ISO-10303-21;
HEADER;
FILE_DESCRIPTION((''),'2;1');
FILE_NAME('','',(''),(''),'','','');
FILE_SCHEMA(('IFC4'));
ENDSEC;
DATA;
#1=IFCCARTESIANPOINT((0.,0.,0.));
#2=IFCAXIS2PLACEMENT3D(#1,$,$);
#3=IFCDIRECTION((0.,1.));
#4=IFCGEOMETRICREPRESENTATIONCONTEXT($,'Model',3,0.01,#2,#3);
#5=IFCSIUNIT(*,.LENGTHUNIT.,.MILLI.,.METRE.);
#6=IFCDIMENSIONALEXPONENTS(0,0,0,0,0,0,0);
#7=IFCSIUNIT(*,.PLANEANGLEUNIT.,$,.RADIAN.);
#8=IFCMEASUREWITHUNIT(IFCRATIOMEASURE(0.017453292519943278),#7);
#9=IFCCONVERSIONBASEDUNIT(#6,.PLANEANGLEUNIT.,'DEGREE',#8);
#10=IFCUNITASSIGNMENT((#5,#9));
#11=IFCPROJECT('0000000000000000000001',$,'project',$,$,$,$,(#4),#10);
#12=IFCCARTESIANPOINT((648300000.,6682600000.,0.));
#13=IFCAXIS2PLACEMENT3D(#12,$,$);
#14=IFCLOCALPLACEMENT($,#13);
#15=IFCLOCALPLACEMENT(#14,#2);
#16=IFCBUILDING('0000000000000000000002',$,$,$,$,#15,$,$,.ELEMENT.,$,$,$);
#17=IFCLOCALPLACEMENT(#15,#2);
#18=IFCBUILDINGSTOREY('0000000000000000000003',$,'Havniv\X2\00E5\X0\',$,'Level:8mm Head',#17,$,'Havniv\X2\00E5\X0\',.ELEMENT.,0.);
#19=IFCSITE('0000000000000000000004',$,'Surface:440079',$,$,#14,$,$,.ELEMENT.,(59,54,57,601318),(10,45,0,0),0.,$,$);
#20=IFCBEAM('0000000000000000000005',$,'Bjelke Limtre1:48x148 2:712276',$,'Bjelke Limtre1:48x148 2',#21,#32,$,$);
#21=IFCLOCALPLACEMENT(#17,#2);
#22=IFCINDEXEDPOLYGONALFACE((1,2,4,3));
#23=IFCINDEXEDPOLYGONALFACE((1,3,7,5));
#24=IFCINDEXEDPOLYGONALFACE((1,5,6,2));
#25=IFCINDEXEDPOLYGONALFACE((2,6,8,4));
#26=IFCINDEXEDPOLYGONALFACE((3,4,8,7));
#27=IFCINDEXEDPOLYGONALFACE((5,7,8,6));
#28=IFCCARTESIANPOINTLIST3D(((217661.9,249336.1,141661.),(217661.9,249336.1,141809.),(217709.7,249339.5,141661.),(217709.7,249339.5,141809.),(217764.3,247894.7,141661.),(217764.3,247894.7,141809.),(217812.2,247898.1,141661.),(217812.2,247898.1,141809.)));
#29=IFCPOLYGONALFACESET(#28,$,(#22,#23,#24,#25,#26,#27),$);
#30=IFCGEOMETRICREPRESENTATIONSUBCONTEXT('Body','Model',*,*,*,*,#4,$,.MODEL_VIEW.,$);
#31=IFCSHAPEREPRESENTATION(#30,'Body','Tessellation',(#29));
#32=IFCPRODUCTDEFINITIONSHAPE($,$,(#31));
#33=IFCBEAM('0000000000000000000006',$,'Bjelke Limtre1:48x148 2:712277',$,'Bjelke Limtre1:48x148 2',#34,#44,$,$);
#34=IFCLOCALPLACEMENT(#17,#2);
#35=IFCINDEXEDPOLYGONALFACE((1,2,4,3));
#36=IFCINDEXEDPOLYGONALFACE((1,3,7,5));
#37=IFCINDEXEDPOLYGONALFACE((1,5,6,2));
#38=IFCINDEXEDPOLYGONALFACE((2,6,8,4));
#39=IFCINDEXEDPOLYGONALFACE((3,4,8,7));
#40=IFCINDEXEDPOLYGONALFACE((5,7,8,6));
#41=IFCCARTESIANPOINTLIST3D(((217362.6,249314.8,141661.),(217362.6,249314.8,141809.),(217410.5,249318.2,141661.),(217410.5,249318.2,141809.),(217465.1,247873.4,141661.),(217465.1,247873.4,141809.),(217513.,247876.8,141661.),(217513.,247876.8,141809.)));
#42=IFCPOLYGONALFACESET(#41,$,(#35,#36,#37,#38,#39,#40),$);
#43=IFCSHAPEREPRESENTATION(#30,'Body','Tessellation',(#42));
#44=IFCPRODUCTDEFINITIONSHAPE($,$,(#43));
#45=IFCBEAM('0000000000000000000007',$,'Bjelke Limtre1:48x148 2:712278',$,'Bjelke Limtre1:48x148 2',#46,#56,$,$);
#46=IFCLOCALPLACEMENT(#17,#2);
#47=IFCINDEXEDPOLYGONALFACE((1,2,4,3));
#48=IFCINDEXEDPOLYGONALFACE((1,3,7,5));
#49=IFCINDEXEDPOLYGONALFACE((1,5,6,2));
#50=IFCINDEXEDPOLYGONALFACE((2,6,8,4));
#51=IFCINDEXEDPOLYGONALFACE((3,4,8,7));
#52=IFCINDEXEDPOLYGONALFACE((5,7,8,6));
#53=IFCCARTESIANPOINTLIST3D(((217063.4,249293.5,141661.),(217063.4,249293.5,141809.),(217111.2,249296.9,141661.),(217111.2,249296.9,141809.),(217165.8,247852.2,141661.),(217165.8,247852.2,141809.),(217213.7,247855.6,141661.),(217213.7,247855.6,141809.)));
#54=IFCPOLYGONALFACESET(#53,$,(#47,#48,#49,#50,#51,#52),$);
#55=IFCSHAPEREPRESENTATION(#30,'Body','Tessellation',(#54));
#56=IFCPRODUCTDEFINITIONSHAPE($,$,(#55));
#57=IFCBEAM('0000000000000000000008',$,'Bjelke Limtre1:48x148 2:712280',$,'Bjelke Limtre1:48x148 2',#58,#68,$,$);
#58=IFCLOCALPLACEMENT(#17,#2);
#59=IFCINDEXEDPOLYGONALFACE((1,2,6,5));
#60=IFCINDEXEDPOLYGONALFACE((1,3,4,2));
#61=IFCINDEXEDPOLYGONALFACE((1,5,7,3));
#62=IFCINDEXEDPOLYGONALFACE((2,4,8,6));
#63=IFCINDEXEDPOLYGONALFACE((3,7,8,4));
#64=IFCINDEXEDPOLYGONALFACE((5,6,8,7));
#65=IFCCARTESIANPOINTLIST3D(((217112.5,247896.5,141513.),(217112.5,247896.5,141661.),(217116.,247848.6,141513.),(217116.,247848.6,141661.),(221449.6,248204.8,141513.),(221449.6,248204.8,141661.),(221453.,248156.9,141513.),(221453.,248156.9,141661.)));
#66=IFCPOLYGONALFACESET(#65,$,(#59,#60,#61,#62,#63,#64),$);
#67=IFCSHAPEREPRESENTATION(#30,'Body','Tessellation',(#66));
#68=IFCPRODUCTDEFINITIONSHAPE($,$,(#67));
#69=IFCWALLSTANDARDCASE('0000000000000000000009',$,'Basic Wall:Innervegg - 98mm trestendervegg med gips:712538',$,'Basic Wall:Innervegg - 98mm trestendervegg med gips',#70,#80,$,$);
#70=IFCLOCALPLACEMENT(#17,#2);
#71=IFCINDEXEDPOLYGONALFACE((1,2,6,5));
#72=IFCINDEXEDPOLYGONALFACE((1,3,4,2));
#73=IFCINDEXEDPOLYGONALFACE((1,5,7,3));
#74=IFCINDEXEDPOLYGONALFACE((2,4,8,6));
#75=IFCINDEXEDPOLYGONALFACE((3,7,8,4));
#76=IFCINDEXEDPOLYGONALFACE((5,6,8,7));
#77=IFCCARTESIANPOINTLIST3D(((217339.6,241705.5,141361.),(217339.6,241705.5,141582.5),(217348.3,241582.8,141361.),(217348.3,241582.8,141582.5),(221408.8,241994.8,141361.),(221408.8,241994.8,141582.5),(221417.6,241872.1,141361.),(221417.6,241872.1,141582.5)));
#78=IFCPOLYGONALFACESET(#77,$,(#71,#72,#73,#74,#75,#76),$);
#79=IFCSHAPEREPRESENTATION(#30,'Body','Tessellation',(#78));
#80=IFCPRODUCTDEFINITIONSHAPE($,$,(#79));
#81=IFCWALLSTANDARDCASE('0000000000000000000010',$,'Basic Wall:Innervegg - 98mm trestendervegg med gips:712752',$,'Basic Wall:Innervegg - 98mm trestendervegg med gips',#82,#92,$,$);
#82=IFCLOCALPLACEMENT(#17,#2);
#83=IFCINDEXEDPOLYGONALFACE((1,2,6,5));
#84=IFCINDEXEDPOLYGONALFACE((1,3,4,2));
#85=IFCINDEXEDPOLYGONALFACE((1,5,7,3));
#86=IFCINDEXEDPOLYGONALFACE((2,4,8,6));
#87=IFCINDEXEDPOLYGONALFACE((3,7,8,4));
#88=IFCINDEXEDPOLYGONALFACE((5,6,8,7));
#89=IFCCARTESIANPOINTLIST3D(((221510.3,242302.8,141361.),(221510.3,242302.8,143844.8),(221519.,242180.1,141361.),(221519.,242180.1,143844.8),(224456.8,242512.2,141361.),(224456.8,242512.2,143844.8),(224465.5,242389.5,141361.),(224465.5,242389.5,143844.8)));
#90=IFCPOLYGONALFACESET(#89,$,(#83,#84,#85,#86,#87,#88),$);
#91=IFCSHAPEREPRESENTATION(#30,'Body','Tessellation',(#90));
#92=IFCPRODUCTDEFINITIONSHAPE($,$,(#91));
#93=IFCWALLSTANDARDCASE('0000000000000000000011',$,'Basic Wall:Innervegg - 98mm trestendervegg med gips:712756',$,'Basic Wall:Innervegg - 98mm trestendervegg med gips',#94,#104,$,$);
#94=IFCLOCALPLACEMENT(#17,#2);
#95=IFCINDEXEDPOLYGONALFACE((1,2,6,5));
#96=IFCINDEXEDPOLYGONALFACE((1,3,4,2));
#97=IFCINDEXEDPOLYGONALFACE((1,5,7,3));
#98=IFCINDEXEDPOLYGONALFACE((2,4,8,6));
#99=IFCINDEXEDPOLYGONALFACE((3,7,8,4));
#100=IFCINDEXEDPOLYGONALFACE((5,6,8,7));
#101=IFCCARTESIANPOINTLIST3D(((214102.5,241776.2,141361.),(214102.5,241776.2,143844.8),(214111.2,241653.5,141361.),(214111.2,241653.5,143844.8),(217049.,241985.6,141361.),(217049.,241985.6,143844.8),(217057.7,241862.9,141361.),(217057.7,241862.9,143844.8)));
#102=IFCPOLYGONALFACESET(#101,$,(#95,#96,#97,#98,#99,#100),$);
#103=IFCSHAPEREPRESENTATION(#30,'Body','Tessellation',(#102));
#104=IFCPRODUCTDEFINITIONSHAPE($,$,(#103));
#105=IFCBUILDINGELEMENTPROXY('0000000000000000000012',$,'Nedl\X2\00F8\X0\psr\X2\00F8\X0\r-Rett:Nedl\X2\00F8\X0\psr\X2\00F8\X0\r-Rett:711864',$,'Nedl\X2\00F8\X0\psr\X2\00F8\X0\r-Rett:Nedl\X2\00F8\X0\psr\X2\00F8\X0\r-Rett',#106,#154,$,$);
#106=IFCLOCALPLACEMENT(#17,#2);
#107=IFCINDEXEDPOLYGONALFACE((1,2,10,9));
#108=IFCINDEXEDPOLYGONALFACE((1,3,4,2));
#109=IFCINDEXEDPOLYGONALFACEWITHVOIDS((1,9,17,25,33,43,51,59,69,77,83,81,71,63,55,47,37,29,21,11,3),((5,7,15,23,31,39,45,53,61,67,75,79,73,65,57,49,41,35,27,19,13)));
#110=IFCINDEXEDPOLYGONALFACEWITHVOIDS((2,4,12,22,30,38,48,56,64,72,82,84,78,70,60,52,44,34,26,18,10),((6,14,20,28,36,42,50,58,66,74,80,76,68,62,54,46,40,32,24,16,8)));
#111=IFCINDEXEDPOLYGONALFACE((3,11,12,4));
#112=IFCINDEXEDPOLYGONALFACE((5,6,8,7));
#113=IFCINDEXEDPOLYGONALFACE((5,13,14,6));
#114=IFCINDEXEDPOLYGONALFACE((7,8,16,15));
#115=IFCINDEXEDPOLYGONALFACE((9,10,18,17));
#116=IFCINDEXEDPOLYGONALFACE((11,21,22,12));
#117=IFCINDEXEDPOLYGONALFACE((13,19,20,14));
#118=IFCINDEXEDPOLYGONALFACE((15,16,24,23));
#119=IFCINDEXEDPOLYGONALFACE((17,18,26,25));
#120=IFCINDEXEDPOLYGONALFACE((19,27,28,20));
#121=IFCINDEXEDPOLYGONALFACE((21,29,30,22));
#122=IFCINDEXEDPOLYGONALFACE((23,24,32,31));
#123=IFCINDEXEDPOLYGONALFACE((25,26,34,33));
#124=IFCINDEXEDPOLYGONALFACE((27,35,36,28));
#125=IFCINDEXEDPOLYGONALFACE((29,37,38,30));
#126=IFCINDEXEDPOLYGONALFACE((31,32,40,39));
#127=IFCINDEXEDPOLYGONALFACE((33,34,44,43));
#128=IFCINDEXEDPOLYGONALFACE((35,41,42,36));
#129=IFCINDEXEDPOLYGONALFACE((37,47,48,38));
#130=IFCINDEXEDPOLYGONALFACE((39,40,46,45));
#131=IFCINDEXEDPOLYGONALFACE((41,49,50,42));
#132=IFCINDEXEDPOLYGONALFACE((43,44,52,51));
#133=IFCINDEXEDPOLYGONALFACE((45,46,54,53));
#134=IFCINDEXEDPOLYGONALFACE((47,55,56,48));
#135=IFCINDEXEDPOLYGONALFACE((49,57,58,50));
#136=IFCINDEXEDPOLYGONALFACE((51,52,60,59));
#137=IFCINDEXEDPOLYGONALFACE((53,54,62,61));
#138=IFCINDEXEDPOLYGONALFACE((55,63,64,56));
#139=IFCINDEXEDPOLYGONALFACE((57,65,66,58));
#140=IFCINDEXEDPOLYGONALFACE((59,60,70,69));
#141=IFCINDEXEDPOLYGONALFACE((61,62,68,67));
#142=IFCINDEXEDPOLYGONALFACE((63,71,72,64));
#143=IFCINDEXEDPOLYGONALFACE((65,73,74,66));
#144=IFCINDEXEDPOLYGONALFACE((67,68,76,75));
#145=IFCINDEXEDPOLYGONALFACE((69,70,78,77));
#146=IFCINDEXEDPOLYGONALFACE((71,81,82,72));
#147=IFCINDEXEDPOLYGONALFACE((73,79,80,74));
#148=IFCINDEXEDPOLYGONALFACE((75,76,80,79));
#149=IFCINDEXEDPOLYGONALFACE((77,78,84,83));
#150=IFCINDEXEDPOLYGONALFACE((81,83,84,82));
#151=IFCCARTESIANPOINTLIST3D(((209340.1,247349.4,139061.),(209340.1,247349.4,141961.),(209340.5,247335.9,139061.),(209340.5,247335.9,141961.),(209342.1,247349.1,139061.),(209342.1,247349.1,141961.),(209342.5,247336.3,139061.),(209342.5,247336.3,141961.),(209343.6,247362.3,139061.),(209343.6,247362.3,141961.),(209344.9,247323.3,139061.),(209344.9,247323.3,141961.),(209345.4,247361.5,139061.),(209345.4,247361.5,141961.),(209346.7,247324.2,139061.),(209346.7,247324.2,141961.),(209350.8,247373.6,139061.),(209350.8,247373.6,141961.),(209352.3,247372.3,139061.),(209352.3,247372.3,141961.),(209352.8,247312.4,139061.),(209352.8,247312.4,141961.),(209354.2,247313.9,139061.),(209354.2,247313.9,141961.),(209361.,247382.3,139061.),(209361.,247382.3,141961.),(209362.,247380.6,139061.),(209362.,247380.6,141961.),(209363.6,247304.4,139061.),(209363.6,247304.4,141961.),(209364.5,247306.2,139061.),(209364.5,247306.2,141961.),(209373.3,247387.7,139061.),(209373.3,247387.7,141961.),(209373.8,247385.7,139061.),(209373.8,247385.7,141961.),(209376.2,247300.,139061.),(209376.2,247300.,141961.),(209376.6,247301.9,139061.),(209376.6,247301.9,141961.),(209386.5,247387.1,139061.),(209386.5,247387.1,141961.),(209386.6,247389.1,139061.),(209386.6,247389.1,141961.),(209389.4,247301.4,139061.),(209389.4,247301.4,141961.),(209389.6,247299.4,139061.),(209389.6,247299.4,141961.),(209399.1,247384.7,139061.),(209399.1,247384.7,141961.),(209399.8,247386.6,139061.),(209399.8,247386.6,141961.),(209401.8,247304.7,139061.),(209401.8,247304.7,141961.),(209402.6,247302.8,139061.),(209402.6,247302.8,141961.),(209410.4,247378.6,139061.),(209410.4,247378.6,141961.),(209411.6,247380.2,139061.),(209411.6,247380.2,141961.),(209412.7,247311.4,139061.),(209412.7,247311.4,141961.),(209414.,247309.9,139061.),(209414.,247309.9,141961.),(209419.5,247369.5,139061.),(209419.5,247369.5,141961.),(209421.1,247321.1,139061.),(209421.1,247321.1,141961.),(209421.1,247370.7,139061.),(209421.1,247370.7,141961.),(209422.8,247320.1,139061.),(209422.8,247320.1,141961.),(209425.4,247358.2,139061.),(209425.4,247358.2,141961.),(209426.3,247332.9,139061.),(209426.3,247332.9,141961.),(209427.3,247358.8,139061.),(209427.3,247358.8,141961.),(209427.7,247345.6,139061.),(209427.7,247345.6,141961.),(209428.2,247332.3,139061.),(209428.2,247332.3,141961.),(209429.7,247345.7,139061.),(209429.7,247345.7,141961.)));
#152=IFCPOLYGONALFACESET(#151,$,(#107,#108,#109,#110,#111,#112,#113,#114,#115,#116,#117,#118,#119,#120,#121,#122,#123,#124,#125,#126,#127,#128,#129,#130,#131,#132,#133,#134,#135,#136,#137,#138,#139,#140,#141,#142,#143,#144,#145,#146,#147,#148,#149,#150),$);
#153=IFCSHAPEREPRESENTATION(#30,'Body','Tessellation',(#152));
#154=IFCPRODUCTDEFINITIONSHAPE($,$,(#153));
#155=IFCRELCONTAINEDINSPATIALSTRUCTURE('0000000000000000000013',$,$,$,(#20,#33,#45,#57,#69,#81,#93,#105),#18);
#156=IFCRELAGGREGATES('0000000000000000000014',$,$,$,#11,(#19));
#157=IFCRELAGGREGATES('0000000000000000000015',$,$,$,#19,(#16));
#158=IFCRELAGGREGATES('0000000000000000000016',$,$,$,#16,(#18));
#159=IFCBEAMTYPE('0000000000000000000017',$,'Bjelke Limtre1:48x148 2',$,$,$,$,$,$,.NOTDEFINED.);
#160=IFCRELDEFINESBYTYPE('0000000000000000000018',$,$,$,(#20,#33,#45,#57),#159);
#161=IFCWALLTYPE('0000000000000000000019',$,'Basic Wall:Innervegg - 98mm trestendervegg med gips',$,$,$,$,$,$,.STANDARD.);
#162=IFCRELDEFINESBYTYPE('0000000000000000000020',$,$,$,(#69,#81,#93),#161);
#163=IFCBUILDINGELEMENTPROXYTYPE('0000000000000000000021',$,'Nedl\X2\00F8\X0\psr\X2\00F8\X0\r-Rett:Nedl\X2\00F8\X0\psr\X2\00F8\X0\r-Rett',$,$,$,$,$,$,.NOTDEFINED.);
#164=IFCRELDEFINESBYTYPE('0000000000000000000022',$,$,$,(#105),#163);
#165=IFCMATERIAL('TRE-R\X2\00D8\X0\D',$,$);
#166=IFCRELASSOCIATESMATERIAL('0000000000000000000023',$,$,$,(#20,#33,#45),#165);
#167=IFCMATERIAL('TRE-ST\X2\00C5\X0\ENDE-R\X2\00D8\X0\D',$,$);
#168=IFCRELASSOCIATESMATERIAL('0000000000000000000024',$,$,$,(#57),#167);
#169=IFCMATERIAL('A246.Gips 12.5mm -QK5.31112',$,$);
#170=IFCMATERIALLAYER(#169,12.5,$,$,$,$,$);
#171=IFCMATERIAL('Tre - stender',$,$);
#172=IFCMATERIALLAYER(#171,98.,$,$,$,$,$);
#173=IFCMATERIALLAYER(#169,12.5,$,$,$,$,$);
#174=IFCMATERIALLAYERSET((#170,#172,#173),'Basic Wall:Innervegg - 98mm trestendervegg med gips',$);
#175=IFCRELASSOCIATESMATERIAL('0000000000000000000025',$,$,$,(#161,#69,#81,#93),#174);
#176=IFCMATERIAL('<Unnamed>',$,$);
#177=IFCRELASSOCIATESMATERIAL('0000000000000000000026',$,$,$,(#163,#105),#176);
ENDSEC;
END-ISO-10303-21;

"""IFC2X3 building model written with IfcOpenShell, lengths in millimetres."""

from ifc_helpers import new_model, entity, si_unit, converted_unit, direction, frame, frame_2d, origin, origin_2d_with_axis, place, context, subcontext, project, spatial, rectangle, hollow_circle, extrude, source, transform, mapped, material, layer, layer_set, layer_usage, type_object, type_shapes, element, save


model = new_model("IFC2X3")

# Units and contexts
model_context = context("Model", 3, precision=0.01, world=origin(), true_north=direction((0.0, 1.0)))
body_context = subcontext(model_context, "Body", "Model", "MODEL_VIEW")
ifc_project = project(units=[si_unit("LENGTHUNIT", "METRE", prefix="MILLI"), converted_unit("PLANEANGLEUNIT", "DEGREE", entity("IfcRatioMeasure", 0.017453292519943278), si_unit("PLANEANGLEUNIT", "RADIAN"), dimensions=[0, 0, 0, 0, 0, 0, 0])], contexts=[model_context])

# Site, building, storey
site_placement = place(None, frame((648300000.0, 6682600000.0, 0.0)))
site = spatial("IfcSite", under=ifc_project, at=site_placement, Name="Surface:440079", CompositionType="ELEMENT", RefLatitude=(59, 54, 57, 601318), RefLongitude=(10, 45, 0, 0), RefElevation=0.0)
building_placement = place(site_placement, origin())
building = spatial("IfcBuilding", under=site, at=building_placement, CompositionType="ELEMENT")
storey_placement = place(building_placement, origin())
storey = spatial("IfcBuildingStorey", under=building, at=storey_placement, Name="Havnivå", ObjectType="Level:8mm Head", LongName="Havnivå", CompositionType="ELEMENT", Elevation=0.0)

# Beams
ifc_material_1 = material(Name="TRE-RØD")
beam_type = type_object("IfcBeamType", Name="Bjelke Limtre1:48x148 2", PredefinedType="NOTDEFINED")
ifc_material_2 = material(Name="TRE-STÅENDE-RØD")
for number, where, z_axis, x_axis, name in (
    (1, (217685.8, 249337.8, 141809.0), (0.0, 0.0, 1.0), (0.070908, -0.997483, 0.0), "Bjelke Limtre1:48x148 2:712276"),
    (2, (217386.5, 249316.5, 141809.0), (0.0, 0.0, 1.0), (0.070908, -0.997483, 0.0), "Bjelke Limtre1:48x148 2:712277"),
    (3, (217087.3, 249295.2, 141809.0), (0.0, 0.0, 1.0), (0.070908, -0.997483, 0.0), "Bjelke Limtre1:48x148 2:712278"),
):
    element("IfcBeam", number, at=place(storey_placement, frame(where, z_axis=z_axis, x_axis=x_axis)), inside=storey, type_object=beam_type, material=ifc_material_1, Name=name, ObjectType="Bjelke Limtre1:48x148 2", context=body_context, shape_type="SweptSolid", body=[
        extrude(rectangle(XDim=148.0, YDim=48.0, at=origin_2d_with_axis()), frame((0.0, 0.0, -74.0), z_axis=(1.0, 0.0, 0.0), x_axis=(0.0, 0.0, -1.0)), (0.0, 0.0, 1.0), 1445.0),
    ])
beam_1_placement = place(storey_placement, frame((217114.3, 247872.6, 141661.0), z_axis=(0.0, 0.0, 1.0), x_axis=(0.997483, 0.070908, 0.0)))
element("IfcBeam", 4, at=beam_1_placement, inside=storey, type_object=beam_type, material=ifc_material_2, Name="Bjelke Limtre1:48x148 2:712280", ObjectType="Bjelke Limtre1:48x148 2", context=body_context, shape_type="SweptSolid", body=[
    extrude(rectangle(XDim=148.0, YDim=48.0, at=frame_2d((0.0, 0.0), x_axis=(1.0, 0.0))), frame((0.0, 0.0, -74.0), z_axis=(1.0, 0.0, 0.0), x_axis=(0.0, 0.0, -1.0)), (0.0, 0.0, 1.0), 4348.0),
])

# Walls
ifc_material_3 = material(Name="A246.Gips 12.5mm -QK5.31112")
ifc_layer_1 = layer(ifc_material_3, 12.5)
ifc_material_4 = material(Name="Tre - stender")
ifc_layer_2 = layer(ifc_material_4, 98.0)
ifc_layer_3 = layer(ifc_material_3, 12.5)
ifc_layer_set_1 = layer_set([ifc_layer_1, ifc_layer_2, ifc_layer_3], Name="Basic Wall:Innervegg - 98mm trestendervegg med gips")
wall_type = type_object("IfcWallType", Name="Basic Wall:Innervegg - 98mm trestendervegg med gips", PredefinedType="STANDARD", material=ifc_layer_set_1)
ifc_layer_usage_1 = layer_usage(ifc_layer_set_1, "AXIS2", "NEGATIVE", 61.5)
wall_1_placement = place(storey_placement, frame((221413.2, 241933.4, 141361.0), z_axis=(0.0, 0.0, 1.0), x_axis=(-0.997483, -0.070908, 0.0)))
element("IfcWallStandardCase", 5, at=wall_1_placement, inside=storey, type_object=wall_type, material=ifc_layer_usage_1, Name="Basic Wall:Innervegg - 98mm trestendervegg med gips:712538", ObjectType="Basic Wall:Innervegg - 98mm trestendervegg med gips", context=body_context, shape_type="SweptSolid", body=[
    extrude(rectangle(XDim=4079.5, YDim=123.0, at=frame_2d((2039.8, 0.0), x_axis=(-1.0, 0.0))), origin(), (0.0, 0.0, 1.0), 221.5),
])
ifc_layer_usage_2 = layer_usage(ifc_layer_set_1, "AXIS2", "NEGATIVE", 61.5)
wall_2_placement = place(storey_placement, frame((224461.2, 242450.9, 141361.0), z_axis=(0.0, 0.0, 1.0), x_axis=(-0.997483, -0.070908, 0.0)))
element("IfcWallStandardCase", 6, at=wall_2_placement, inside=storey, type_object=wall_type, material=ifc_layer_usage_2, Name="Basic Wall:Innervegg - 98mm trestendervegg med gips:712752", ObjectType="Basic Wall:Innervegg - 98mm trestendervegg med gips", context=body_context, shape_type="SweptSolid", body=[
    extrude(rectangle(XDim=2954.0, YDim=123.0, at=frame_2d((1477.0, 0.0), x_axis=(-1.0, 0.0))), origin(), (0.0, 0.0, 1.0), 2483.8),
])
ifc_layer_usage_3 = layer_usage(ifc_layer_set_1, "AXIS2", "NEGATIVE", 61.5)
wall_3_placement = place(storey_placement, frame((217053.4, 241924.3, 141361.0), z_axis=(0.0, 0.0, 1.0), x_axis=(-0.997483, -0.070908, 0.0)))
element("IfcWallStandardCase", 7, at=wall_3_placement, inside=storey, type_object=wall_type, material=ifc_layer_usage_3, Name="Basic Wall:Innervegg - 98mm trestendervegg med gips:712756", ObjectType="Basic Wall:Innervegg - 98mm trestendervegg med gips", context=body_context, shape_type="SweptSolid", body=[
    extrude(rectangle(XDim=2954.0, YDim=123.0, at=frame_2d((1477.0, 0.0), x_axis=(-1.0, 0.0))), origin(), (0.0, 0.0, 1.0), 2483.8),
])

# Building element proxy
ifc_material_5 = material(Name="<Unnamed>")
building_element_proxy_type_1 = type_object("IfcBuildingElementProxyType", Name="Nedløpsrør-Rett:Nedløpsrør-Rett", PredefinedType="NOTDEFINED", material=ifc_material_5)
shared_shape_1 = source(origin(), body_context, "Body", "SweptSolid", [
    extrude(hollow_circle(Radius=45.0, WallThickness=2.0, at=frame_2d((0.0, 0.0), x_axis=(1.0, 0.0))), frame((0.0, 0.0, 0.0), z_axis=(0.0, 0.0, 1.0), x_axis=(-1.0, 0.0, 0.0)), (0.0, 0.0, 1.0), 2900.0),
])
type_shapes(building_element_proxy_type_1, [shared_shape_1])
for number, where, z_axis, x_axis, name in (
    (8, (209384.8, 247344.1, 139061.0), (0.0, 0.0, 1.0), (0.755467, -0.655187, 0.0), "Nedløpsrør-Rett:Nedløpsrør-Rett:711864"),
):
    element("IfcBuildingElementProxy", number, at=place(storey_placement, frame(where, z_axis=z_axis, x_axis=x_axis)), inside=storey, type_object=building_element_proxy_type_1, material=ifc_material_5, Name=name, ObjectType="Nedløpsrør-Rett:Nedløpsrør-Rett", context=body_context, shape_type="MappedRepresentation", body=[
        mapped(shared_shape_1, transform((0.0, 0.0, 0.0), scale=1.0)),
    ])

save(model, "model.ifc")
